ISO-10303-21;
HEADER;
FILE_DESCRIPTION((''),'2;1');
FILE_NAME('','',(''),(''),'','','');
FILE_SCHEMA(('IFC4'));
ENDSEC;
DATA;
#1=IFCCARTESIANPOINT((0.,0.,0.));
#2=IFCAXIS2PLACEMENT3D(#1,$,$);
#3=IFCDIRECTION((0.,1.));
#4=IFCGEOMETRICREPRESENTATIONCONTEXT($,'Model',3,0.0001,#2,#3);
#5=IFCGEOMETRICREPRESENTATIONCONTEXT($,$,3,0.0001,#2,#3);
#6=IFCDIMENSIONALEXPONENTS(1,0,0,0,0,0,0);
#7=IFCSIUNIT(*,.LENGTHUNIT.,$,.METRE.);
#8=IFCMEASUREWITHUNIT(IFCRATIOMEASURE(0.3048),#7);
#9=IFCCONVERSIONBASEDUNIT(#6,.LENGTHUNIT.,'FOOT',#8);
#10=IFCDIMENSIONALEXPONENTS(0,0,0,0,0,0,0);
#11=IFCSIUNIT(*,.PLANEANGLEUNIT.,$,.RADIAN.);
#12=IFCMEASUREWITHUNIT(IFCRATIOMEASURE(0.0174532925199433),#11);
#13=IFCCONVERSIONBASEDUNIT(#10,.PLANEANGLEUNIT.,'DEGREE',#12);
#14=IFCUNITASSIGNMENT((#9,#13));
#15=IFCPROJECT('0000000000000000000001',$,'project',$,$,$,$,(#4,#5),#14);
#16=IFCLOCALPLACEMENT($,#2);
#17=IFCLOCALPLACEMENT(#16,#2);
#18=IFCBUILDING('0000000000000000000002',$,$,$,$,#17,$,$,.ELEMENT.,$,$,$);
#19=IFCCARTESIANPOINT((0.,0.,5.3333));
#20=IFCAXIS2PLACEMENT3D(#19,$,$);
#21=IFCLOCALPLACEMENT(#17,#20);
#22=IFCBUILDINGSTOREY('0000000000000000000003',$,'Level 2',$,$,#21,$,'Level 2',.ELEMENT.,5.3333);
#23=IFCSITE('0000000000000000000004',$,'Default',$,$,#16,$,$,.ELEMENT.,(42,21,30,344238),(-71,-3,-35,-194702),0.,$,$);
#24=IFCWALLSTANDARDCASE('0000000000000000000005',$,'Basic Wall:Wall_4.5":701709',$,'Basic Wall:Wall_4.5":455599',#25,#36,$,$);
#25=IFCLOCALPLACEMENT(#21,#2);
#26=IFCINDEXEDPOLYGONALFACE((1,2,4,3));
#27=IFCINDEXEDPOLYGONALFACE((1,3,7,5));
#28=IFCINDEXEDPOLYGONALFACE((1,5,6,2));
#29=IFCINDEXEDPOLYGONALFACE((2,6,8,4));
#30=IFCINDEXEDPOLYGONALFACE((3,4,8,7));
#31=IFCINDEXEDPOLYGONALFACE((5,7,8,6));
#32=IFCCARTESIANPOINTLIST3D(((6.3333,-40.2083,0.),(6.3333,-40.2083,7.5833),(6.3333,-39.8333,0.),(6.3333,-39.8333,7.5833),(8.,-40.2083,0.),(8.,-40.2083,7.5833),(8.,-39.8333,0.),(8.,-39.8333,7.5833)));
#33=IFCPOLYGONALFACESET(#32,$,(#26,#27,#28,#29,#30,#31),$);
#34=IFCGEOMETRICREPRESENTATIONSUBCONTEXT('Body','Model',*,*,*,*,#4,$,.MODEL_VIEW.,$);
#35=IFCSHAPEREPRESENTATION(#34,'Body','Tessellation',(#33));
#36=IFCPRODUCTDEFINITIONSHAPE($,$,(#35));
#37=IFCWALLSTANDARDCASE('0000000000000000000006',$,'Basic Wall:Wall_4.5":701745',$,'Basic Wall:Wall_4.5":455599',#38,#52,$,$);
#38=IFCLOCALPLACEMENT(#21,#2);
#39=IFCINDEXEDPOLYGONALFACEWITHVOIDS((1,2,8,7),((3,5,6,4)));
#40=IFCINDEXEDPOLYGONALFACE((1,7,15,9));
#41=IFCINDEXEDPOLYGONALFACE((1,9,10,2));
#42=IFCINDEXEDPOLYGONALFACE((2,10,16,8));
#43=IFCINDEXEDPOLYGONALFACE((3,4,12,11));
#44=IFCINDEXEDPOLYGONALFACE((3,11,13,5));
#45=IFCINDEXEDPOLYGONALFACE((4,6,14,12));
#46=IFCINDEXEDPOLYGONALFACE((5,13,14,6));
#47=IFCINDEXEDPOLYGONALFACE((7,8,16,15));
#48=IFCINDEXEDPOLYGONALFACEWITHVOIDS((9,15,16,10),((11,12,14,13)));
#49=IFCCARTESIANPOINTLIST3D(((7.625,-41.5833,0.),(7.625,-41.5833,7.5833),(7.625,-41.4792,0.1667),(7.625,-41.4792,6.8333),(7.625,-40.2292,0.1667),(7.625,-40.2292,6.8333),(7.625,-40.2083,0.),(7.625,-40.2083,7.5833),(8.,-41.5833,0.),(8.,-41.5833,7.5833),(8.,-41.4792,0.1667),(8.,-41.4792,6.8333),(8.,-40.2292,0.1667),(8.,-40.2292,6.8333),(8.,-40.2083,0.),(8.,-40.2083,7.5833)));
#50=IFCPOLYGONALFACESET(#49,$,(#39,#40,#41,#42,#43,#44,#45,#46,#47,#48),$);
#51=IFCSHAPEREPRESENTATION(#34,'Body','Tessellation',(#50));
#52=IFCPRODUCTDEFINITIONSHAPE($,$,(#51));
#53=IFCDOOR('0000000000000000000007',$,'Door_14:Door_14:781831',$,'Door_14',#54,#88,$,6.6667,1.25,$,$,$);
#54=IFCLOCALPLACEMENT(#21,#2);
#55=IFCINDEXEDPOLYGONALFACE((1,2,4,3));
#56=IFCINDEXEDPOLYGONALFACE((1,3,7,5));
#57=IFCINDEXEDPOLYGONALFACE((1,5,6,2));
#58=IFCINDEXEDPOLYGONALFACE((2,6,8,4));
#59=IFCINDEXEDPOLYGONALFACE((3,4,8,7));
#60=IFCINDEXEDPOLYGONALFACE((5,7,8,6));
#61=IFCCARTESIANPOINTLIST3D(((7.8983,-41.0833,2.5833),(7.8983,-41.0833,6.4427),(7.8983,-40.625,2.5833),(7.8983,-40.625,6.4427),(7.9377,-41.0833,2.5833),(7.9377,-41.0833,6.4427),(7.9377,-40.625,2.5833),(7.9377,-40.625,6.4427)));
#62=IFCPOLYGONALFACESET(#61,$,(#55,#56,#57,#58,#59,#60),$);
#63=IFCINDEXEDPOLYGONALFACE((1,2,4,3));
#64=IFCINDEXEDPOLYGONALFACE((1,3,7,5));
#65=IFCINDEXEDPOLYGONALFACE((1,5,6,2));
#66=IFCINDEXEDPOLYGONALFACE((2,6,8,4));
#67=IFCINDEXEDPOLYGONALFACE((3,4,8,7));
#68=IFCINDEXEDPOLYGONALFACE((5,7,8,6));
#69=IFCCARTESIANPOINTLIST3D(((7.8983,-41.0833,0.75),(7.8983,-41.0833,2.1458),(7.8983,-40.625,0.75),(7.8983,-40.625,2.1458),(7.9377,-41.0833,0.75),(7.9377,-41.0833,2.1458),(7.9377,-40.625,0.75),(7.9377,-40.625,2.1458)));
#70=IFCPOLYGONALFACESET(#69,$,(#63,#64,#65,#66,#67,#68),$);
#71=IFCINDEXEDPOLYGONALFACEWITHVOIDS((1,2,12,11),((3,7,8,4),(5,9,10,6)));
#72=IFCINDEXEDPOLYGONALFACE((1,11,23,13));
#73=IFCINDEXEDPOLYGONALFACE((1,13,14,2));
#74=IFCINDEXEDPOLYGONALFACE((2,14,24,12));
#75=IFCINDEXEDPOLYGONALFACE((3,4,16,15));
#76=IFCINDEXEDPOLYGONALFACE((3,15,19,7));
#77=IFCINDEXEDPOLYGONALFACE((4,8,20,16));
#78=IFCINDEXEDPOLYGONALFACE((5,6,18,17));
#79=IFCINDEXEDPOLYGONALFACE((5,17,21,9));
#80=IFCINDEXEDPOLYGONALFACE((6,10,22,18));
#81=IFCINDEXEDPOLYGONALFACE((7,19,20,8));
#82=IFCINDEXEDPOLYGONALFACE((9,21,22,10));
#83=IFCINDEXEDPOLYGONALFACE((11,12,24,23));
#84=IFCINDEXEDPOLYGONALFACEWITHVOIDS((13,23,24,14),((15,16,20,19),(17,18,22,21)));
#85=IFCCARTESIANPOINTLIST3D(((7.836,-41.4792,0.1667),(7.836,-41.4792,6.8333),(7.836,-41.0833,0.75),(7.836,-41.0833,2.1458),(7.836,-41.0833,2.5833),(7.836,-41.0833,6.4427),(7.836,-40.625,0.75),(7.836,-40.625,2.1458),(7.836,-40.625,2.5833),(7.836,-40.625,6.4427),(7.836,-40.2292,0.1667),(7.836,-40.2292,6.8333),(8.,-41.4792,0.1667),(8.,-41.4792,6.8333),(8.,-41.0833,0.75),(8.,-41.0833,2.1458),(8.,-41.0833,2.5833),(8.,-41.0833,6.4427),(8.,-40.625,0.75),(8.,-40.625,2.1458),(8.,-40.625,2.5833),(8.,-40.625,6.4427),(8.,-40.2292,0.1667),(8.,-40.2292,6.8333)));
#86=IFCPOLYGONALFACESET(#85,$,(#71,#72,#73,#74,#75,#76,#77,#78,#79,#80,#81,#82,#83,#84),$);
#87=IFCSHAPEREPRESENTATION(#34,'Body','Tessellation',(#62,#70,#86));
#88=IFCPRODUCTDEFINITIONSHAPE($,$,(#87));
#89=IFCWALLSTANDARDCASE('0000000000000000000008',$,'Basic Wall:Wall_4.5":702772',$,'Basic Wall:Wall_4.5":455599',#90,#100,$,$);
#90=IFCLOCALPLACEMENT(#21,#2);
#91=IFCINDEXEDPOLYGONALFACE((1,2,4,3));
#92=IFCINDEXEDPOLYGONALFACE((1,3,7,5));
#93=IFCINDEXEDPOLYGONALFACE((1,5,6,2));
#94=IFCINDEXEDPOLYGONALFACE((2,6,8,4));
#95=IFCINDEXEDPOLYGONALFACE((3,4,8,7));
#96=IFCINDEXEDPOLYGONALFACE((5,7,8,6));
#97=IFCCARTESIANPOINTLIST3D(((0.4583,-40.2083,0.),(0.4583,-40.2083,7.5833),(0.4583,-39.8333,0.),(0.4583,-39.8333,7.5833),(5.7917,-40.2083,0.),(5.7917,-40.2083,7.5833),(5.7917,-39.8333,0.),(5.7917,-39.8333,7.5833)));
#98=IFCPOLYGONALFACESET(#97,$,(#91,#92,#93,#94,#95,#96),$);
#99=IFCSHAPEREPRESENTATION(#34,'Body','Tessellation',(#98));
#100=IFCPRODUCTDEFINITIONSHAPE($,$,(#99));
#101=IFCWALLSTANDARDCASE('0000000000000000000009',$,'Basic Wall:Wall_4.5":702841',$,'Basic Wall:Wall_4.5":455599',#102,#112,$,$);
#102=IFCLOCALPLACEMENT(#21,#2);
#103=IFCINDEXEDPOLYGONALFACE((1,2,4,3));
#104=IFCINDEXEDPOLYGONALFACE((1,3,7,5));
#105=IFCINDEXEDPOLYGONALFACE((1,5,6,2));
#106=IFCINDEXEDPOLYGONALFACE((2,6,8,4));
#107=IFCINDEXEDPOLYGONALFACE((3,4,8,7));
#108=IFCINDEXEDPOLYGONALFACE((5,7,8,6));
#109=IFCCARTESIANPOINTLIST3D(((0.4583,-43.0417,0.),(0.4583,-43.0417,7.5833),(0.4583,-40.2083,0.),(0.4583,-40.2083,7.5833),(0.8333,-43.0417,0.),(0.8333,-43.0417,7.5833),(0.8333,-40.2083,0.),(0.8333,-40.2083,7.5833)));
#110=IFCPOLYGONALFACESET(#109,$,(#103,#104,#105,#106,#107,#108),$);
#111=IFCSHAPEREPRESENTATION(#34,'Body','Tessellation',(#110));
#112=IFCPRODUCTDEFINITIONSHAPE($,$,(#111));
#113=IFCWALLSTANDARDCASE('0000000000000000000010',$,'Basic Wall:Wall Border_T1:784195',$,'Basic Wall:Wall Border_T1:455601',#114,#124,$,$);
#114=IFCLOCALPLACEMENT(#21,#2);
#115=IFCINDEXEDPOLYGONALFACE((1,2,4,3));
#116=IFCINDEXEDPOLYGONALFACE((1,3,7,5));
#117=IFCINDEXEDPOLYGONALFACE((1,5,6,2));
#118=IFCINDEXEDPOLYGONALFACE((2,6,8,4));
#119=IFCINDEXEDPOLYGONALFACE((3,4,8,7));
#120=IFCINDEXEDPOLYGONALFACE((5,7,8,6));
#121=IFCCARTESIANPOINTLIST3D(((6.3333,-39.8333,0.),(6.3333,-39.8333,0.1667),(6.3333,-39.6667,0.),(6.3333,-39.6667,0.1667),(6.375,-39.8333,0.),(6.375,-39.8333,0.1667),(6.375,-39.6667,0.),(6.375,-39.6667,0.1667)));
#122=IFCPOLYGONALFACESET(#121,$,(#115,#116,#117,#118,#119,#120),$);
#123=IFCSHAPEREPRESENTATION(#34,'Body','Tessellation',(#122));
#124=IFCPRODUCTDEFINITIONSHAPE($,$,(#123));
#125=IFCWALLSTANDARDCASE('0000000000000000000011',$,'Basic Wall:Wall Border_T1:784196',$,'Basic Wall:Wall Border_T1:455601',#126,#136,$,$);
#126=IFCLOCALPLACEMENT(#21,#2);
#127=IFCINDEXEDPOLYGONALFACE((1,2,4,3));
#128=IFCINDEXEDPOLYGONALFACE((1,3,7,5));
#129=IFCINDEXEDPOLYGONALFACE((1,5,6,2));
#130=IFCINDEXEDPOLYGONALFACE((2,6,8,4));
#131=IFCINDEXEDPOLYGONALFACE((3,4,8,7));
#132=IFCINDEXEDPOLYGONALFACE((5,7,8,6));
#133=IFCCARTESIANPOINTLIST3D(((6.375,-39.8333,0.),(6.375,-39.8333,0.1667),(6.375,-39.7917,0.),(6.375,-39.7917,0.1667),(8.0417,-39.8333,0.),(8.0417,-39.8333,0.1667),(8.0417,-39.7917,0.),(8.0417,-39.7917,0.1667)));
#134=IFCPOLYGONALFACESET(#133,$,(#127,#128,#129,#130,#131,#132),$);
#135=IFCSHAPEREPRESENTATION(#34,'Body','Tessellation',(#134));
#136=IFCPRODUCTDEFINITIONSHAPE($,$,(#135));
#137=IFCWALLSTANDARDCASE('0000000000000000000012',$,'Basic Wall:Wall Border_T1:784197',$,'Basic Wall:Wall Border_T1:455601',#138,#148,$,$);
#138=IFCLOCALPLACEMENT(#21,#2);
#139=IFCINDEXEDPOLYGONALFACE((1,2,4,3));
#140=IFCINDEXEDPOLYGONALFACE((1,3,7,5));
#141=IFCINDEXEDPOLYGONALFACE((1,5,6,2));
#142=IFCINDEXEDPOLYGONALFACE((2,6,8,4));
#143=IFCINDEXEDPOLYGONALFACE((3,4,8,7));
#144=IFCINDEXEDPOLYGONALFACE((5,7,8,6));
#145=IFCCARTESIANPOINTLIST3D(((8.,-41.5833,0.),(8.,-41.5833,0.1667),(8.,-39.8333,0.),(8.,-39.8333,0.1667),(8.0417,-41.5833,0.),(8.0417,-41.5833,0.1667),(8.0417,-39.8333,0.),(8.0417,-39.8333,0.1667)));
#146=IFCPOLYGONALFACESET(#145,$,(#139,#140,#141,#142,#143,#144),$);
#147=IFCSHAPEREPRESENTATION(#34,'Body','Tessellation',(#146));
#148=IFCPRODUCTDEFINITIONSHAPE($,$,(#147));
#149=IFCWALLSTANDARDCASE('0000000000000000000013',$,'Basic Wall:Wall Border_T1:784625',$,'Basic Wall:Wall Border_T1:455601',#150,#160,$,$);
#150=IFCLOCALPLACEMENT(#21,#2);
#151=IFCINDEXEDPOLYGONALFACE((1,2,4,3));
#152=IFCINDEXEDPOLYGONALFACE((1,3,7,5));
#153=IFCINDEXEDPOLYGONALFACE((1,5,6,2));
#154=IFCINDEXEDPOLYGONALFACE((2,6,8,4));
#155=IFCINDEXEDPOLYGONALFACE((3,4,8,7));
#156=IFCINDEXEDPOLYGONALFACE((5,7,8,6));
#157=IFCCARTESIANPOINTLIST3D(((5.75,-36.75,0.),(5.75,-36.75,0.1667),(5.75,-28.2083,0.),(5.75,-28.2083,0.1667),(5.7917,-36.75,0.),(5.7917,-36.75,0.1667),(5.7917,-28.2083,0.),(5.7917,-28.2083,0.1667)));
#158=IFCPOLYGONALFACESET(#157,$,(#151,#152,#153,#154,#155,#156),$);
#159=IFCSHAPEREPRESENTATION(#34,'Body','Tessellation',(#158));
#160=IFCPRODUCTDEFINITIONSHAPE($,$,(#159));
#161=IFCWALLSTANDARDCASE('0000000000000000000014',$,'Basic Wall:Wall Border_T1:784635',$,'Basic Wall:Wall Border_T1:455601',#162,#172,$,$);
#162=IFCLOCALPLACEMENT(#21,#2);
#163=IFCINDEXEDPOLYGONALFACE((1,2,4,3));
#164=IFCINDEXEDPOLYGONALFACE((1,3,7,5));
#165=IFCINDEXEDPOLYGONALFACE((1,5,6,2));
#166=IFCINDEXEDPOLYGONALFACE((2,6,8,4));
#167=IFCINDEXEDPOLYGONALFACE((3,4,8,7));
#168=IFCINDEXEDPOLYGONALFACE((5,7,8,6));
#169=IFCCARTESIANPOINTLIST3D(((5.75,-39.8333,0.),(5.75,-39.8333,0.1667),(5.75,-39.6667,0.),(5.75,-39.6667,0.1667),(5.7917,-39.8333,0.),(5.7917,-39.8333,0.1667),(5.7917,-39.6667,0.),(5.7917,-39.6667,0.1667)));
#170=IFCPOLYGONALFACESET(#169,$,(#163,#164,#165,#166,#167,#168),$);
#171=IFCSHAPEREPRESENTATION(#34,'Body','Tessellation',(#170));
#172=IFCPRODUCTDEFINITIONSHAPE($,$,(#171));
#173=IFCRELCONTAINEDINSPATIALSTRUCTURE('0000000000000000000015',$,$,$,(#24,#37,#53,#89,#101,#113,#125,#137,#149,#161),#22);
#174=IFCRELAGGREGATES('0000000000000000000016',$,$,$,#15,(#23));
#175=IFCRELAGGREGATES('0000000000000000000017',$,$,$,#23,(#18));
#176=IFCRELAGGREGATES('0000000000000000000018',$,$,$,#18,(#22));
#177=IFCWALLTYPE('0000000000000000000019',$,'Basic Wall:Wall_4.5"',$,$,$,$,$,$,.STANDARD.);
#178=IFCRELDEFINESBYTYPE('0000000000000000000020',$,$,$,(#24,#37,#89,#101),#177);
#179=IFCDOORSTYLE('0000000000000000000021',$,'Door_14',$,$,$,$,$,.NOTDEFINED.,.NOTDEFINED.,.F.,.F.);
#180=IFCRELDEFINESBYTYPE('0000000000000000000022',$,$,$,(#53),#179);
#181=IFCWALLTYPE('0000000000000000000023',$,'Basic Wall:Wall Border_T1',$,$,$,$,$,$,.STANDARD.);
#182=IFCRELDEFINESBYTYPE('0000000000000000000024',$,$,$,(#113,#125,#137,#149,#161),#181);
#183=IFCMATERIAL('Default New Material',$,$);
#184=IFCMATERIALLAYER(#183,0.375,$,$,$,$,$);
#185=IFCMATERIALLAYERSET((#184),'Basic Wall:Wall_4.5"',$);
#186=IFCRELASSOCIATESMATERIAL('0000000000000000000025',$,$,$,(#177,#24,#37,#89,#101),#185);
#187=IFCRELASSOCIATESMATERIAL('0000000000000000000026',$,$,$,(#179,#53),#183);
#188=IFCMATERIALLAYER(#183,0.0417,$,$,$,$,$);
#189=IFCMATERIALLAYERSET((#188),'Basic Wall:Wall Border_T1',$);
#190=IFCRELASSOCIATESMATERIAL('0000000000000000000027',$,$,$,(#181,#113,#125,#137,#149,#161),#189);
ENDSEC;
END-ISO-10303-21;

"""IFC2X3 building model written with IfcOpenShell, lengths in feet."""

from ifc_helpers import new_model, entity, si_unit, converted_unit, direction, frame, frame_2d, origin, origin_2d_with_axis, place, context, subcontext, project, spatial, polyline, rectangle, outline, extrude, source, transform, mapped, material, layer, layer_set, layer_usage, type_object, type_shapes, element, fill, save


model = new_model("IFC2X3")

# Units and contexts
model_context = context("Model", 3, precision=0.0001, world=origin(), true_north=direction((0.0, 1.0)))
context_of_model = context(None, 3, precision=0.0001, world=origin(), true_north=direction((0.0, 1.0)))
body_context = subcontext(model_context, "Body", "Model", "MODEL_VIEW")
ifc_project = project(units=[converted_unit("LENGTHUNIT", "FOOT", entity("IfcRatioMeasure", 0.3048), si_unit("LENGTHUNIT", "METRE"), dimensions=[1, 0, 0, 0, 0, 0, 0]), converted_unit("PLANEANGLEUNIT", "DEGREE", entity("IfcRatioMeasure", 0.0174532925199433), si_unit("PLANEANGLEUNIT", "RADIAN"), dimensions=[0, 0, 0, 0, 0, 0, 0])], contexts=[model_context, context_of_model])

# Site, building, storey
site_placement = place(None, origin())
site = spatial("IfcSite", under=ifc_project, at=site_placement, Name="Default", CompositionType="ELEMENT", RefLatitude=(42, 21, 30, 344238), RefLongitude=(-71, -3, -35, -194702), RefElevation=0.0)
building_placement = place(site_placement, origin())
building = spatial("IfcBuilding", under=site, at=building_placement, CompositionType="ELEMENT")
storey_placement = place(building_placement, frame((0.0, 0.0, 5.3333)))
storey = spatial("IfcBuildingStorey", under=building, at=storey_placement, Name="Level 2", LongName="Level 2", CompositionType="ELEMENT", Elevation=5.3333)

# Wall
ifc_material = material(Name="Default New Material")
ifc_layer_1 = layer(ifc_material, 0.375)
ifc_layer_set_1 = layer_set([ifc_layer_1], Name="Basic Wall:Wall_4.5\"")
ifc_layer_usage_1 = layer_usage(ifc_layer_set_1, "AXIS2", "NEGATIVE", 0.1875)
wall_type_1 = type_object("IfcWallType", Name="Basic Wall:Wall_4.5\"", PredefinedType="STANDARD", material=ifc_layer_set_1)
wall_1_placement = place(storey_placement, frame((6.3333, -40.0208, 0.0)))
element("IfcWallStandardCase", 1, at=wall_1_placement, inside=storey, type_object=wall_type_1, material=ifc_layer_usage_1, Name="Basic Wall:Wall_4.5\":701709", ObjectType="Basic Wall:Wall_4.5\":455599", context=body_context, shape_type="SweptSolid", body=[
    extrude(rectangle(XDim=1.6667, YDim=0.375, at=frame_2d((0.8333, 0.0), x_axis=(-1.0, 0.0))), origin(), (0.0, 0.0, 1.0), 7.5833),
])

# Wall, opening, door
ifc_layer_usage_2 = layer_usage(ifc_layer_set_1, "AXIS2", "NEGATIVE", 0.1875)
wall_2_placement = place(storey_placement, frame((7.8125, -40.2083, 0.0), z_axis=(0.0, 0.0, 1.0), x_axis=(0.0, -1.0, 0.0)))
wall_2 = element("IfcWallStandardCase", 2, at=wall_2_placement, inside=storey, type_object=wall_type_1, material=ifc_layer_usage_2, Name="Basic Wall:Wall_4.5\":701745", ObjectType="Basic Wall:Wall_4.5\":455599", context=body_context, shape_type="SweptSolid", body=[
    extrude(rectangle(XDim=1.375, YDim=0.375, at=frame_2d((0.6875, 0.0), x_axis=(-1.0, 0.0))), origin(), (0.0, 0.0, 1.0), 7.5833),
])
opening_placement = place(wall_2_placement, frame((0.0208, -0.1875, 0.1667)))
opening = element("IfcOpeningElement", 3, at=opening_placement, cuts=wall_2, ObjectType="Opening", context=body_context, shape_type="SweptSolid", body=[
    extrude(rectangle(XDim=6.6667, YDim=1.25, at=frame_2d((3.3333, 0.625), x_axis=(1.0, 0.0))), frame((0.0, 0.0, 0.0), z_axis=(0.0, 1.0, 0.0), x_axis=(0.0, 0.0, 1.0)), (0.0, 0.0, 1.0), 0.375),
])
door_style = type_object("IfcDoorStyle", Name="Door_14", ConstructionType="NOTDEFINED", OperationType="NOTDEFINED", ParameterTakesPrecedence=False, Sizeable=False, material=ifc_material)
shared_shape_1 = source(origin(), body_context, "Body", "SweptSolid", [
    extrude(rectangle(XDim=0.0394, YDim=0.4583, at=origin_2d_with_axis()), frame((0.625, 0.293, 2.4167), z_axis=(0.0, 0.0, 1.0), x_axis=(0.0, 1.0, 0.0)), (0.0, 0.0, 1.0), 3.8594),
    extrude(rectangle(XDim=0.0394, YDim=0.4583, at=origin_2d_with_axis()), frame((0.625, 0.293, 0.5833), z_axis=(0.0, 0.0, 1.0), x_axis=(0.0, 1.0, 0.0)), (0.0, 0.0, 1.0), 1.3958),
    extrude(outline(polyline([(-0.625, -3.3333), (0.625, -3.3333), (0.625, 3.3333), (-0.625, 3.3333), (-0.625, -3.3333)]), holes=[polyline([(-0.2292, -2.9427), (-0.2292, 0.9167), (0.2292, 0.9167), (0.2292, -2.9427), (-0.2292, -2.9427)]), polyline([(-0.2292, 1.3542), (-0.2292, 2.75), (0.2292, 2.75), (0.2292, 1.3542), (-0.2292, 1.3542)])]), frame((0.625, 0.211, 3.3333), z_axis=(0.0, 1.0, 0.0), x_axis=(1.0, 0.0, 0.0)), (0.0, 0.0, 1.0), 0.164),
])
type_shapes(door_style, [shared_shape_1])
door_placement = place(opening_placement, origin())
door = element("IfcDoor", 4, at=door_placement, inside=storey, type_object=door_style, material=ifc_material, Name="Door_14:Door_14:781831", ObjectType="Door_14", OverallHeight=6.6667, OverallWidth=1.25, context=body_context, shape_type="MappedRepresentation", body=[
    mapped(shared_shape_1, transform((0.0, 0.0, 0.0), scale=1.0)),
])
fill(opening, door)

# Walls
ifc_layer_usage_3 = layer_usage(ifc_layer_set_1, "AXIS2", "NEGATIVE", 0.1875)
wall_3_placement = place(storey_placement, frame((5.7917, -40.0208, 0.0), z_axis=(0.0, 0.0, 1.0), x_axis=(-1.0, 0.0, 0.0)))
element("IfcWallStandardCase", 5, at=wall_3_placement, inside=storey, type_object=wall_type_1, material=ifc_layer_usage_3, Name="Basic Wall:Wall_4.5\":702772", ObjectType="Basic Wall:Wall_4.5\":455599", context=body_context, shape_type="SweptSolid", body=[
    extrude(rectangle(XDim=5.3333, YDim=0.375, at=frame_2d((2.6667, 0.0), x_axis=(-1.0, 0.0))), origin(), (0.0, 0.0, 1.0), 7.5833),
])
ifc_layer_usage_4 = layer_usage(ifc_layer_set_1, "AXIS2", "NEGATIVE", 0.1875)
wall_4_placement = place(storey_placement, frame((0.6458, -40.2083, 0.0), z_axis=(0.0, 0.0, 1.0), x_axis=(0.0, -1.0, 0.0)))
element("IfcWallStandardCase", 6, at=wall_4_placement, inside=storey, type_object=wall_type_1, material=ifc_layer_usage_4, Name="Basic Wall:Wall_4.5\":702841", ObjectType="Basic Wall:Wall_4.5\":455599", context=body_context, shape_type="SweptSolid", body=[
    extrude(rectangle(XDim=2.8333, YDim=0.375, at=frame_2d((1.4167, 0.0), x_axis=(-1.0, 0.0))), origin(), (0.0, 0.0, 1.0), 7.5833),
])
ifc_layer_2 = layer(ifc_material, 0.0417)
ifc_layer_set_2 = layer_set([ifc_layer_2], Name="Basic Wall:Wall Border_T1")
ifc_layer_usage_5 = layer_usage(ifc_layer_set_2, "AXIS2", "NEGATIVE", 0.0208)
wall_type_2 = type_object("IfcWallType", Name="Basic Wall:Wall Border_T1", PredefinedType="STANDARD", material=ifc_layer_set_2)
wall_5_placement = place(storey_placement, frame((6.3542, -39.6667, 0.0), z_axis=(0.0, 0.0, 1.0), x_axis=(0.0, -1.0, 0.0)))
element("IfcWallStandardCase", 7, at=wall_5_placement, inside=storey, type_object=wall_type_2, material=ifc_layer_usage_5, Name="Basic Wall:Wall Border_T1:784195", ObjectType="Basic Wall:Wall Border_T1:455601", context=body_context, shape_type="SweptSolid", body=[
    extrude(rectangle(XDim=0.1667, YDim=0.0417, at=frame_2d((0.0833, 0.0), x_axis=(-1.0, 0.0))), origin(), (0.0, 0.0, 1.0), 0.1667),
])
ifc_layer_usage_6 = layer_usage(ifc_layer_set_2, "AXIS2", "NEGATIVE", 0.0208)
wall_6_placement = place(storey_placement, frame((6.375, -39.8125, 0.0)))
element("IfcWallStandardCase", 8, at=wall_6_placement, inside=storey, type_object=wall_type_2, material=ifc_layer_usage_6, Name="Basic Wall:Wall Border_T1:784196", ObjectType="Basic Wall:Wall Border_T1:455601", context=body_context, shape_type="SweptSolid", body=[
    extrude(rectangle(XDim=1.6667, YDim=0.0417, at=frame_2d((0.8333, 0.0), x_axis=(-1.0, 0.0))), origin(), (0.0, 0.0, 1.0), 0.1667),
])
ifc_layer_usage_7 = layer_usage(ifc_layer_set_2, "AXIS2", "NEGATIVE", 0.0208)
wall_7_placement = place(storey_placement, frame((8.0208, -39.8333, 0.0), z_axis=(0.0, 0.0, 1.0), x_axis=(0.0, -1.0, 0.0)))
element("IfcWallStandardCase", 9, at=wall_7_placement, inside=storey, type_object=wall_type_2, material=ifc_layer_usage_7, Name="Basic Wall:Wall Border_T1:784197", ObjectType="Basic Wall:Wall Border_T1:455601", context=body_context, shape_type="SweptSolid", body=[
    extrude(rectangle(XDim=1.75, YDim=0.0417, at=frame_2d((0.875, 0.0), x_axis=(-1.0, 0.0))), origin(), (0.0, 0.0, 1.0), 0.1667),
])
ifc_layer_usage_8 = layer_usage(ifc_layer_set_2, "AXIS2", "NEGATIVE", 0.0208)
wall_8_placement = place(storey_placement, frame((5.7708, -36.75, 0.0), z_axis=(0.0, 0.0, 1.0), x_axis=(0.0, 1.0, 0.0)))
element("IfcWallStandardCase", 10, at=wall_8_placement, inside=storey, type_object=wall_type_2, material=ifc_layer_usage_8, Name="Basic Wall:Wall Border_T1:784625", ObjectType="Basic Wall:Wall Border_T1:455601", context=body_context, shape_type="SweptSolid", body=[
    extrude(rectangle(XDim=8.5417, YDim=0.0417, at=frame_2d((4.2708, 0.0), x_axis=(-1.0, 0.0))), origin(), (0.0, 0.0, 1.0), 0.1667),
])
ifc_layer_usage_9 = layer_usage(ifc_layer_set_2, "AXIS2", "POSITIVE", -0.0208)
wall_9_placement = place(storey_placement, frame((5.7708, -39.6667, 0.0), z_axis=(0.0, 0.0, 1.0), x_axis=(0.0, -1.0, 0.0)))
element("IfcWallStandardCase", 11, at=wall_9_placement, inside=storey, type_object=wall_type_2, material=ifc_layer_usage_9, Name="Basic Wall:Wall Border_T1:784635", ObjectType="Basic Wall:Wall Border_T1:455601", context=body_context, shape_type="SweptSolid", body=[
    extrude(rectangle(XDim=0.1667, YDim=0.0417, at=frame_2d((0.0833, 0.0), x_axis=(-1.0, 0.0))), origin(), (0.0, 0.0, 1.0), 0.1667),
])

save(model, "model.ifc")
